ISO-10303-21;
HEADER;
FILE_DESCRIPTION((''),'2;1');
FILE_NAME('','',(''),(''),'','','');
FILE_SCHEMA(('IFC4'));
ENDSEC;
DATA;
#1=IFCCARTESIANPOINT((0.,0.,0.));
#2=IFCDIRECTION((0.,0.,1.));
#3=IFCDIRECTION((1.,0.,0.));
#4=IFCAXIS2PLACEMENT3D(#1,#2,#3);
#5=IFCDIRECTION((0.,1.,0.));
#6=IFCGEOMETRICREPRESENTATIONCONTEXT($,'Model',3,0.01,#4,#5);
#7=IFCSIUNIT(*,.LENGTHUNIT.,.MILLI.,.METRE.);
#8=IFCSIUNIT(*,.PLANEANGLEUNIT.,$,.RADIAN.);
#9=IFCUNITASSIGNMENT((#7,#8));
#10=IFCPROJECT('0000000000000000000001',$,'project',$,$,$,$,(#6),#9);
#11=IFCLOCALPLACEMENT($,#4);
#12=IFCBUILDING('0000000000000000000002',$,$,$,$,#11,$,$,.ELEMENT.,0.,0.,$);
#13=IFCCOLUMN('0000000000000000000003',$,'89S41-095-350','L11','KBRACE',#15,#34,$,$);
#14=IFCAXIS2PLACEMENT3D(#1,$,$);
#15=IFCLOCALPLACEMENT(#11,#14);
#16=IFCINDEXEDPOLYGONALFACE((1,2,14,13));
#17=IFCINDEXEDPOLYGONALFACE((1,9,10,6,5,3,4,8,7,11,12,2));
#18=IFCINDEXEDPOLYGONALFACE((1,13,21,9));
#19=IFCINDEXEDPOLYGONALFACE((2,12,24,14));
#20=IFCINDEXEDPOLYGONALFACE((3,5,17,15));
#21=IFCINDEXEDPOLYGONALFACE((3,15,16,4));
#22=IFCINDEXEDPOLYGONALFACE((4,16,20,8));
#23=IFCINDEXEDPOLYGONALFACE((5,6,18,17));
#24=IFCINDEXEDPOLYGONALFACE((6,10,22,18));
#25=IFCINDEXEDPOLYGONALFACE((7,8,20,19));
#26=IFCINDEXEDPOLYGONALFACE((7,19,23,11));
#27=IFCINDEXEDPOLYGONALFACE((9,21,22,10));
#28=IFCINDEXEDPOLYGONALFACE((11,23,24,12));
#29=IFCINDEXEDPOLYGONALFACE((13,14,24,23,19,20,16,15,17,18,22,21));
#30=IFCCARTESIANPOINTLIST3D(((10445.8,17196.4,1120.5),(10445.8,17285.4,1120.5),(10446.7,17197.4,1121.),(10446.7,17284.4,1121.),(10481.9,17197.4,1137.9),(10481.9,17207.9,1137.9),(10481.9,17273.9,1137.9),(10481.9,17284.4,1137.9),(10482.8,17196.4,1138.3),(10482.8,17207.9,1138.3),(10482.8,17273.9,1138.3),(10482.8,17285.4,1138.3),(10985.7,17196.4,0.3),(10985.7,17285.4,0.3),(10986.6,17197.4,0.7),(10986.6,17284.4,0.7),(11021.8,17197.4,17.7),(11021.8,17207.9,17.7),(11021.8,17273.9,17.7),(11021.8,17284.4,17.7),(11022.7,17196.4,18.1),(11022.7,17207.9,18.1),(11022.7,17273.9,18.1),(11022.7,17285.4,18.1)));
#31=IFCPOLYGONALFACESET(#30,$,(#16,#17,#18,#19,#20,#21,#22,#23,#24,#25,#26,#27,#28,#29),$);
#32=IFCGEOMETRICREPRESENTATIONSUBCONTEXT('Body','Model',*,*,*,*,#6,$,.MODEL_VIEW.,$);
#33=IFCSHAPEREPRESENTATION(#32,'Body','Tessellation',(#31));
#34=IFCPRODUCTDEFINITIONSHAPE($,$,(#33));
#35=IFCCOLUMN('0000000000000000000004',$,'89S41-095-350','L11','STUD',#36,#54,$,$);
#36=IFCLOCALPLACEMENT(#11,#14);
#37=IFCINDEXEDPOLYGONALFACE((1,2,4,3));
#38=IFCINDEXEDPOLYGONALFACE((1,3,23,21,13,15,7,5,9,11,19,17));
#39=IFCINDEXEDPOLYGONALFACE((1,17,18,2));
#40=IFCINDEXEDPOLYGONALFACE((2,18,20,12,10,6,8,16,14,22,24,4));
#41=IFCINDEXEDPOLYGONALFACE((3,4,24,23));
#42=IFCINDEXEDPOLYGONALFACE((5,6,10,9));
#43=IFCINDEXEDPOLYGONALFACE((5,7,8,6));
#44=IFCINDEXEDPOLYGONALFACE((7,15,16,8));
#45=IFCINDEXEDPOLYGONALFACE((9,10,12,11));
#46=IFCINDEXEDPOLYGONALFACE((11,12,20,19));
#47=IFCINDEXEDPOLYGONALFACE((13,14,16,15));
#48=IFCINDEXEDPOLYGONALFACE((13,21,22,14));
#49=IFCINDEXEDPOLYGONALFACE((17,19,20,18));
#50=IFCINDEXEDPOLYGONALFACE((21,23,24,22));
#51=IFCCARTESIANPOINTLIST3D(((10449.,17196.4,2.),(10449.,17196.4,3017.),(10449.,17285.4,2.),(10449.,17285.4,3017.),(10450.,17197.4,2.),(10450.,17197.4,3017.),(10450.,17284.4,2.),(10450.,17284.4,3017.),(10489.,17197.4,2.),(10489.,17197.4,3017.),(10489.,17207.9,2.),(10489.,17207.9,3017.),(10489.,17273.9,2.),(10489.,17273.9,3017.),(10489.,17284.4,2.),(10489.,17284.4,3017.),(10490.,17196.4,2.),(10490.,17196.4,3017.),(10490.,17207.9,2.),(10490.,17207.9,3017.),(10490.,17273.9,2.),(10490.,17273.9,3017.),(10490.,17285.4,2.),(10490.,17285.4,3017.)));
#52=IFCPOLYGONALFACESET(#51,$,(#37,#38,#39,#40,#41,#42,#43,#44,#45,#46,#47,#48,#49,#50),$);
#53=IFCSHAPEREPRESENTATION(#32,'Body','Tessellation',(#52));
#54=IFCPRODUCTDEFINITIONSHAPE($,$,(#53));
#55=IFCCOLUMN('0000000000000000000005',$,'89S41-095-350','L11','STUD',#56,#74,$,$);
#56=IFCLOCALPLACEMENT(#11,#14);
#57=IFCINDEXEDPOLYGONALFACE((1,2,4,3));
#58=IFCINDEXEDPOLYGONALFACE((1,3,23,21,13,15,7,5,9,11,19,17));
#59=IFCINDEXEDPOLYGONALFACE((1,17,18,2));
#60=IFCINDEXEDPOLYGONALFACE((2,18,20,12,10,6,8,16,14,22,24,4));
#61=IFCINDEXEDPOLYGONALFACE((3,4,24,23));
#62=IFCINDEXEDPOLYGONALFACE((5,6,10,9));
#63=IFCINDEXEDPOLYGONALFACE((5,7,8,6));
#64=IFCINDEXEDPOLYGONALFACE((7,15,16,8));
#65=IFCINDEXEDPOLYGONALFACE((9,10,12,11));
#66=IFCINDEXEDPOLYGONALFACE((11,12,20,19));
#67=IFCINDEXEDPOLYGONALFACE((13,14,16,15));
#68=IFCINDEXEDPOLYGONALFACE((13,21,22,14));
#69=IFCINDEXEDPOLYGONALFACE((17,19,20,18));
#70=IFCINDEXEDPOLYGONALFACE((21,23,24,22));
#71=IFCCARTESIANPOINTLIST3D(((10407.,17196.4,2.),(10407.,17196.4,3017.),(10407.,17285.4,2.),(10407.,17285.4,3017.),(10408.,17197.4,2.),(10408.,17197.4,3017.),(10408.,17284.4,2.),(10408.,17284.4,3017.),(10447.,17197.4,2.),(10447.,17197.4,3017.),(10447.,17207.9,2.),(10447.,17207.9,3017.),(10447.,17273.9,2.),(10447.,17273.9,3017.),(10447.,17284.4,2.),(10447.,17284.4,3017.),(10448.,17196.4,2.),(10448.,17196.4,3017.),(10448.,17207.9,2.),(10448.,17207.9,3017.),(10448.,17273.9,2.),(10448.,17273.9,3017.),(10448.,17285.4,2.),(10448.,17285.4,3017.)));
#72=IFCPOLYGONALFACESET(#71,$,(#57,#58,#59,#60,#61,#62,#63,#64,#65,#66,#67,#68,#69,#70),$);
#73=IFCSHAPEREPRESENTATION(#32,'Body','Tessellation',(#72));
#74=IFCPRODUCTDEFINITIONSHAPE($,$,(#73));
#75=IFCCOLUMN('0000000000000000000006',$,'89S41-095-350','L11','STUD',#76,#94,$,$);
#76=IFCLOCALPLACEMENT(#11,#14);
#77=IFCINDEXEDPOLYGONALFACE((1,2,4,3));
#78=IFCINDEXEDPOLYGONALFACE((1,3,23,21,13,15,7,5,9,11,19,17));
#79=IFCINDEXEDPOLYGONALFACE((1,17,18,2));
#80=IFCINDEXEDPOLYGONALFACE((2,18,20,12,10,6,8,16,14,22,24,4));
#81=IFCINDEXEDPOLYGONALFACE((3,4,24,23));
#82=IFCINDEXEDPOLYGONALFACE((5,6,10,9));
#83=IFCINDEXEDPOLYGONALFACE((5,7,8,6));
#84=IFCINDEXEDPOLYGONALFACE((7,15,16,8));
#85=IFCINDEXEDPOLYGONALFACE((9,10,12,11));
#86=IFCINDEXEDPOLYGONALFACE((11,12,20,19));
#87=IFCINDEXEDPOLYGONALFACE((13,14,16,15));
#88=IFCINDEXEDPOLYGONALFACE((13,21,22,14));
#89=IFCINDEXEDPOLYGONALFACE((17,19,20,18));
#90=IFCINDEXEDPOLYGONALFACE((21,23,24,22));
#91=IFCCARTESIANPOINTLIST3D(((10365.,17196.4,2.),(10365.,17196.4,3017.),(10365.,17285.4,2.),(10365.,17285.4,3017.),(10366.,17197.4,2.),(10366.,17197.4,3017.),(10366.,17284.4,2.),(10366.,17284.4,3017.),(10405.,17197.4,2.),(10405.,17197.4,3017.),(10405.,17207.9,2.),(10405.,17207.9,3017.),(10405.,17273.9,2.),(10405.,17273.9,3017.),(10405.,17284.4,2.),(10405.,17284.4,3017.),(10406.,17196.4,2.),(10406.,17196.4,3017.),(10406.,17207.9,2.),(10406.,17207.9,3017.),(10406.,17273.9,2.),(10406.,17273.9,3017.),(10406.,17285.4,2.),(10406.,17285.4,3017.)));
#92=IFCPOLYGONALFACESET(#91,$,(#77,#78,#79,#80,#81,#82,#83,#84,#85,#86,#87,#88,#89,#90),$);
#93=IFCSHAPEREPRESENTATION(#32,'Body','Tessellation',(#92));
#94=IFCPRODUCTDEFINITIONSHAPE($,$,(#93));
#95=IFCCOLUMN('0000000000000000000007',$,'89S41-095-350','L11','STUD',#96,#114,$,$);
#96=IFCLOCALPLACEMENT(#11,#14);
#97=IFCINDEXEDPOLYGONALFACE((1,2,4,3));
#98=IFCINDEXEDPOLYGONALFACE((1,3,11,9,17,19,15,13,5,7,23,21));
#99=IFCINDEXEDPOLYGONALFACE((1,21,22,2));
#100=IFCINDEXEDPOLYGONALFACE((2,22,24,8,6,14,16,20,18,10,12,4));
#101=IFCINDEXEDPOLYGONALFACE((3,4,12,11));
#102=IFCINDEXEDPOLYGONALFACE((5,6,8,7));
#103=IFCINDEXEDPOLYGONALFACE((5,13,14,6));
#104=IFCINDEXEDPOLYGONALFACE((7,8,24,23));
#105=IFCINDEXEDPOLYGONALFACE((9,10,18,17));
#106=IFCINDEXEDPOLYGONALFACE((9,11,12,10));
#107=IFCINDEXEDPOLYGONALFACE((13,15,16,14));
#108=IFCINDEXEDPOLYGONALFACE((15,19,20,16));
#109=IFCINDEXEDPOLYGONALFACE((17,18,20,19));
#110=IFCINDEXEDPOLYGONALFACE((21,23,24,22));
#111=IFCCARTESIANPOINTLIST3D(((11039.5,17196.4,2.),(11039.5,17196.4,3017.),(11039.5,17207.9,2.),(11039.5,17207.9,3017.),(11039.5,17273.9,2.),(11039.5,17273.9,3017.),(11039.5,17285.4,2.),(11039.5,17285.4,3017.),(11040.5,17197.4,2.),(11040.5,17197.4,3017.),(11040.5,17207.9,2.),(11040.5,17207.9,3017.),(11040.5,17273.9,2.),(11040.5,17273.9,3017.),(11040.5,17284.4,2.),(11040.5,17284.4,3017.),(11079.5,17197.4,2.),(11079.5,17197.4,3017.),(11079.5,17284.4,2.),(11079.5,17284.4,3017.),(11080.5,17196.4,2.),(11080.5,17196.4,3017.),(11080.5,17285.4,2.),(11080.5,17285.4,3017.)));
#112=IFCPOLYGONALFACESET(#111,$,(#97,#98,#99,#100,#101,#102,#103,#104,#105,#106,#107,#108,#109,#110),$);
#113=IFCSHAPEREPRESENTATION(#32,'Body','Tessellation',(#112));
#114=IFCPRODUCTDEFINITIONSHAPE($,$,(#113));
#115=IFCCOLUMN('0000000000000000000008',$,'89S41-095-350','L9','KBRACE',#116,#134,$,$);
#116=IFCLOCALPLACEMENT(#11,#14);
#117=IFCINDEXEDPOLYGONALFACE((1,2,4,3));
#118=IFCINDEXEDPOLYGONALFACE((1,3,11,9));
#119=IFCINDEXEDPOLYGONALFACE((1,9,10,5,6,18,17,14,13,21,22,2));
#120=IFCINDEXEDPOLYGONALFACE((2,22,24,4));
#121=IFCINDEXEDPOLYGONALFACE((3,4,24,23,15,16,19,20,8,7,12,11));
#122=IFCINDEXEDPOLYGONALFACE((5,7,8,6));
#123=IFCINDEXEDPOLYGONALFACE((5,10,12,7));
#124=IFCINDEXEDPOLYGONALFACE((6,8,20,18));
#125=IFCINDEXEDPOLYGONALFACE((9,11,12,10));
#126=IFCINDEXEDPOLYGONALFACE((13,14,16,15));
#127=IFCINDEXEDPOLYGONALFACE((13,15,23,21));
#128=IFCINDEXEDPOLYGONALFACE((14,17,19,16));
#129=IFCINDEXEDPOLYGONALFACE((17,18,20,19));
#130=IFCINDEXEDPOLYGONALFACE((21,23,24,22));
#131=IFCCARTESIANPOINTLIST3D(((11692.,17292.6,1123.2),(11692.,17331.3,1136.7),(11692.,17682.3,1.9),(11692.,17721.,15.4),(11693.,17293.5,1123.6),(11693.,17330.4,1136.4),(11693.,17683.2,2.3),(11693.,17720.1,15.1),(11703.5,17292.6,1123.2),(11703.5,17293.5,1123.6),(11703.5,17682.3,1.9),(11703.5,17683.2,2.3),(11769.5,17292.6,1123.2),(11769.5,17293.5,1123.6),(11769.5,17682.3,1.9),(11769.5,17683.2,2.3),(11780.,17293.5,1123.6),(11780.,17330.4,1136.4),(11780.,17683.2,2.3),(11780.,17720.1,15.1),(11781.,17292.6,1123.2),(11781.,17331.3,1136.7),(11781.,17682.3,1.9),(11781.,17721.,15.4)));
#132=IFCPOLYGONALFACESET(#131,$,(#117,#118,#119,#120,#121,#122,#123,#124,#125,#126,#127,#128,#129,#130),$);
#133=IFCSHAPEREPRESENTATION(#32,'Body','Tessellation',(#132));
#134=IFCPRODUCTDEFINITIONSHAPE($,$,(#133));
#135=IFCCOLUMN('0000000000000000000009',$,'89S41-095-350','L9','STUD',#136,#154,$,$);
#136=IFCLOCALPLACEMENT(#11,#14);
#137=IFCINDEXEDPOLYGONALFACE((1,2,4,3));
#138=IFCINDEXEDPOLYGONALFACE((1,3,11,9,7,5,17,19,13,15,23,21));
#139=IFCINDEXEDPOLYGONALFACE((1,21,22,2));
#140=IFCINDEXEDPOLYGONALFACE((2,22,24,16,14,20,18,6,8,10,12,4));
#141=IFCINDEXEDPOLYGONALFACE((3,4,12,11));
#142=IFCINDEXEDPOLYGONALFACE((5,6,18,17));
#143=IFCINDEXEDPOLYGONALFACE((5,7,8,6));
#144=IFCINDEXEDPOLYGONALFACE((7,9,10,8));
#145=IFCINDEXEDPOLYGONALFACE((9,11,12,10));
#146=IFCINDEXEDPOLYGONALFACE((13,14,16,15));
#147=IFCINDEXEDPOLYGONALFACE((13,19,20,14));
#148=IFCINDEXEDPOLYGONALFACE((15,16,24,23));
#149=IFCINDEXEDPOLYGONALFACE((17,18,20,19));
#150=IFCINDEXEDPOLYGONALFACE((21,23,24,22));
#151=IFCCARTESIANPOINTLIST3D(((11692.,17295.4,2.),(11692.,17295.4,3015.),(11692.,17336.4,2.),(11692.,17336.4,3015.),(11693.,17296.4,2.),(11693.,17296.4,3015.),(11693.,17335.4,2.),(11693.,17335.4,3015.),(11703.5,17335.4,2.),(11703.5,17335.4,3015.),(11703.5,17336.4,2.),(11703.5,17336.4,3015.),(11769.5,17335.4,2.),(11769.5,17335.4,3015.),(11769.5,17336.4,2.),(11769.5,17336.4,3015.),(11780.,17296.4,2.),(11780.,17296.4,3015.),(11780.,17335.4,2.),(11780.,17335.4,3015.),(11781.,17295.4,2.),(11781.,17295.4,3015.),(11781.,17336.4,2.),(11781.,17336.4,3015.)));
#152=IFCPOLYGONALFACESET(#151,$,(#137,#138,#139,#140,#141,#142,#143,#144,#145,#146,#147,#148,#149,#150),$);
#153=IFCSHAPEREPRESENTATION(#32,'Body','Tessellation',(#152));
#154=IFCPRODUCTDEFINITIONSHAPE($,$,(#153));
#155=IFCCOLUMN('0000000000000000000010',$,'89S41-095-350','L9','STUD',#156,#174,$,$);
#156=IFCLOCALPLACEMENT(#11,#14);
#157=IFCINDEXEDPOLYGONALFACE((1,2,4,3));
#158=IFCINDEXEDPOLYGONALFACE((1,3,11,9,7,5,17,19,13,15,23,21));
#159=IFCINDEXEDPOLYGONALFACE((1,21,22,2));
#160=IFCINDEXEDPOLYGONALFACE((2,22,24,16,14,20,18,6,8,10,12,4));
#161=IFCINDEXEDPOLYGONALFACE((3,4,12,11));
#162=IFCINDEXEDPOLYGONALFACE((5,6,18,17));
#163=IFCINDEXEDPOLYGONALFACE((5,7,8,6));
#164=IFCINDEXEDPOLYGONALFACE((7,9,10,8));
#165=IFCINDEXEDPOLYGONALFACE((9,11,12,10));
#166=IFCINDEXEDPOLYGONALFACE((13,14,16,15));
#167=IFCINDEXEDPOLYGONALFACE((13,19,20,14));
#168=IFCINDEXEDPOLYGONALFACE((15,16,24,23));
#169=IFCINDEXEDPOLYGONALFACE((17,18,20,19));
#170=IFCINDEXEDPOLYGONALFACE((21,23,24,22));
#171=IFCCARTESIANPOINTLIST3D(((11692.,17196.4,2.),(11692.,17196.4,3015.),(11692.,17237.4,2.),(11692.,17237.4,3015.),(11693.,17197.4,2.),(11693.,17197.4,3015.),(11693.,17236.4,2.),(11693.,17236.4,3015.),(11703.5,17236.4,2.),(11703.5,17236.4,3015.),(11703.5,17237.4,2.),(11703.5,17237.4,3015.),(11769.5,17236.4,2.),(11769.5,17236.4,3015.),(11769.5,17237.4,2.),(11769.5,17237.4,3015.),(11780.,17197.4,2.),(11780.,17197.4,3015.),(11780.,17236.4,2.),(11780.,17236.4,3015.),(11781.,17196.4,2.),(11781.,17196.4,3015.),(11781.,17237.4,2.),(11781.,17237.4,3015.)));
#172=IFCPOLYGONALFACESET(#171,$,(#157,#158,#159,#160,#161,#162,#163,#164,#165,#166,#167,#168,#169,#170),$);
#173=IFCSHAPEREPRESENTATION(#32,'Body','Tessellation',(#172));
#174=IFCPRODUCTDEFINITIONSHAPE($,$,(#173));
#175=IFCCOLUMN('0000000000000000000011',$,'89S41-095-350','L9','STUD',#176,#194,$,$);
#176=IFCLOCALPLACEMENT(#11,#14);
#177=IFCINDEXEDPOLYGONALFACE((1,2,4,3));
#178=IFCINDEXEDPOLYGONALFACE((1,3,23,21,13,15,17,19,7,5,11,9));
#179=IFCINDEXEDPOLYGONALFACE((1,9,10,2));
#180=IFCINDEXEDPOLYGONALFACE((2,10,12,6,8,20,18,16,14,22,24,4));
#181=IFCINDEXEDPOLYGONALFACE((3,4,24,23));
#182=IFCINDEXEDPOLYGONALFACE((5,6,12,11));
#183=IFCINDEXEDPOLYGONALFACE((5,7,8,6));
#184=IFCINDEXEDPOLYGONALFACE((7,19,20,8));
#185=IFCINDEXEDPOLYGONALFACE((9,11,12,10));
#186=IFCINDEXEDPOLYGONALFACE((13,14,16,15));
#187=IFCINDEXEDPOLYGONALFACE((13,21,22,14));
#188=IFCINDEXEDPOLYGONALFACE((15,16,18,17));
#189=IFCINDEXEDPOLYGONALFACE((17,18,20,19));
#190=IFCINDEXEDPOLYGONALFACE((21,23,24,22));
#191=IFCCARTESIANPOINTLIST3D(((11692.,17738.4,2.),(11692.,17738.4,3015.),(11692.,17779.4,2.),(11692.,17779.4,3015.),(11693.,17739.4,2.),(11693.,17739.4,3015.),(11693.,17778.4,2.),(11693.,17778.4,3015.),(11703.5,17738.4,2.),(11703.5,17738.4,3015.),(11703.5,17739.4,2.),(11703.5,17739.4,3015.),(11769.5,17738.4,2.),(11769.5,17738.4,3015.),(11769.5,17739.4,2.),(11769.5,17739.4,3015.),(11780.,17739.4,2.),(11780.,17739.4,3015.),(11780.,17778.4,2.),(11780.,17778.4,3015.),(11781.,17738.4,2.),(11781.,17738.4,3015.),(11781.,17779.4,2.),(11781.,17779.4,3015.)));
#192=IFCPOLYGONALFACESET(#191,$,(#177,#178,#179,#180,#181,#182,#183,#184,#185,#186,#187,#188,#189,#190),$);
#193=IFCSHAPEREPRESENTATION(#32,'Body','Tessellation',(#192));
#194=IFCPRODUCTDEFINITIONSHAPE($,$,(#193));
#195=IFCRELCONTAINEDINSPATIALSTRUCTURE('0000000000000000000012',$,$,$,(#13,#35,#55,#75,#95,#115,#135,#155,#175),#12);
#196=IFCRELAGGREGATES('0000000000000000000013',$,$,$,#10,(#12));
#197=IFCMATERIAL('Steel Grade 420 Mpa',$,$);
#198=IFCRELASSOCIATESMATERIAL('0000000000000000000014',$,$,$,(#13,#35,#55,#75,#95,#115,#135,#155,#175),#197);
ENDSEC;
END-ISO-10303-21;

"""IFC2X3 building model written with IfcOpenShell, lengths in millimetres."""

from ifc_helpers import new_model, si_unit, direction, frame, origin, origin_with_axes, origin_2d_with_axis, place, context, subcontext, project, spatial, c_section, extrude, source, transform, mapped, material, element, save


model = new_model("IFC2X3")

# Units and contexts
model_context = context("Model", 3, precision=0.01, world=origin_with_axes(), true_north=direction((0.0, 1.0, 0.0)))
body_context = subcontext(model_context, "Body", "Model", "MODEL_VIEW")
ifc_project = project(units=[si_unit("LENGTHUNIT", "METRE", prefix="MILLI"), si_unit("PLANEANGLEUNIT", "RADIAN")], contexts=[model_context])

# Building
building_placement = place(None, origin_with_axes())
building = spatial("IfcBuilding", under=ifc_project, at=building_placement, CompositionType="ELEMENT", ElevationOfRefHeight=0.0, ElevationOfTerrain=0.0)

# Columns
ifc_material = material(Name="Steel Grade 420 Mpa")
shared_shape_1 = source(origin(), body_context, "Body", "SweptSolid", [
    extrude(c_section(Depth=89.0, Width=41.0, WallThickness=1.0, Girth=11.5, at=origin_2d_with_axis()), origin_with_axes(), (0.0, 0.0, 1.0), 1243.6),
])
column_1_placement = place(None, frame((11004.2, 17240.9, 9.2), z_axis=(-0.43416, 0.0, 0.900836), x_axis=(0.900836, 0.0, 0.43416)))
element("IfcColumn", 1, at=column_1_placement, inside=building, material=ifc_material, Name="89S41-095-350", Description="L11", ObjectType="KBRACE", context=body_context, shape_type="MappedRepresentation", body=[
    mapped(shared_shape_1, transform((0.0, 0.0, 0.0), scale=1.0)),
])
shared_shape_2 = source(origin(), body_context, "Body", "SweptSolid", [
    extrude(c_section(Depth=89.0, Width=41.0, WallThickness=1.0, Girth=11.5, at=origin_2d_with_axis()), origin_with_axes(), (0.0, 0.0, 1.0), 3015.0),
])
column_2_placement = place(None, frame((10469.5, 17240.9, 2.0), z_axis=(0.0, 0.0, 1.0), x_axis=(1.0, 0.0, 0.0)))
element("IfcColumn", 2, at=column_2_placement, inside=building, material=ifc_material, Name="89S41-095-350", Description="L11", ObjectType="STUD", context=body_context, shape_type="MappedRepresentation", body=[
    mapped(shared_shape_2, transform((0.0, 0.0, 0.0), scale=1.0)),
])
shared_shape_3 = source(origin(), body_context, "Body", "SweptSolid", [
    extrude(c_section(Depth=89.0, Width=41.0, WallThickness=1.0, Girth=11.5, at=origin_2d_with_axis()), origin_with_axes(), (0.0, 0.0, 1.0), 3015.0),
])
column_3_placement = place(None, frame((10427.5, 17240.9, 2.0), z_axis=(0.0, 0.0, 1.0), x_axis=(1.0, 0.0, 0.0)))
element("IfcColumn", 3, at=column_3_placement, inside=building, material=ifc_material, Name="89S41-095-350", Description="L11", ObjectType="STUD", context=body_context, shape_type="MappedRepresentation", body=[
    mapped(shared_shape_3, transform((0.0, 0.0, 0.0), scale=1.0)),
])
shared_shape_4 = source(origin(), body_context, "Body", "SweptSolid", [
    extrude(c_section(Depth=89.0, Width=41.0, WallThickness=1.0, Girth=11.5, at=origin_2d_with_axis()), origin_with_axes(), (0.0, 0.0, 1.0), 3015.0),
])
column_4_placement = place(None, frame((10385.5, 17240.9, 2.0), z_axis=(0.0, 0.0, 1.0), x_axis=(1.0, 0.0, 0.0)))
element("IfcColumn", 4, at=column_4_placement, inside=building, material=ifc_material, Name="89S41-095-350", Description="L11", ObjectType="STUD", context=body_context, shape_type="MappedRepresentation", body=[
    mapped(shared_shape_4, transform((0.0, 0.0, 0.0), scale=1.0)),
])
shared_shape_5 = source(origin(), body_context, "Body", "SweptSolid", [
    extrude(c_section(Depth=89.0, Width=41.0, WallThickness=1.0, Girth=11.5, at=origin_2d_with_axis()), origin_with_axes(), (0.0, 0.0, 1.0), 3015.0),
])
column_5_placement = place(None, frame((11060.0, 17240.9, 2.0), z_axis=(0.0, 0.0, 1.0), x_axis=(-1.0, 0.0, 0.0)))
element("IfcColumn", 5, at=column_5_placement, inside=building, material=ifc_material, Name="89S41-095-350", Description="L11", ObjectType="STUD", context=body_context, shape_type="MappedRepresentation", body=[
    mapped(shared_shape_5, transform((0.0, 0.0, 0.0), scale=1.0)),
])
shared_shape_6 = source(origin(), body_context, "Body", "SweptSolid", [
    extrude(c_section(Depth=89.0, Width=41.0, WallThickness=1.0, Girth=11.5, at=origin_2d_with_axis()), origin_with_axes(), (0.0, 0.0, 1.0), 1187.1),
])
column_6_placement = place(None, frame((11736.5, 17701.7, 8.7), z_axis=(0.0, -0.328306, 0.944572), x_axis=(0.0, -0.944572, -0.328306)))
element("IfcColumn", 6, at=column_6_placement, inside=building, material=ifc_material, Name="89S41-095-350", Description="L9", ObjectType="KBRACE", context=body_context, shape_type="MappedRepresentation", body=[
    mapped(shared_shape_6, transform((0.0, 0.0, 0.0), scale=1.0)),
])
shared_shape_7 = source(origin(), body_context, "Body", "SweptSolid", [
    extrude(c_section(Depth=89.0, Width=41.0, WallThickness=1.0, Girth=11.5, at=origin_2d_with_axis()), origin_with_axes(), (0.0, 0.0, 1.0), 3013.0),
])
column_7_placement = place(None, frame((11736.5, 17315.9, 2.0), z_axis=(0.0, 0.0, 1.0), x_axis=(0.0, 1.0, 0.0)))
element("IfcColumn", 7, at=column_7_placement, inside=building, material=ifc_material, Name="89S41-095-350", Description="L9", ObjectType="STUD", context=body_context, shape_type="MappedRepresentation", body=[
    mapped(shared_shape_7, transform((0.0, 0.0, 0.0), scale=1.0)),
])
shared_shape_8 = source(origin(), body_context, "Body", "SweptSolid", [
    extrude(c_section(Depth=89.0, Width=41.0, WallThickness=1.0, Girth=11.5, at=origin_2d_with_axis()), origin_with_axes(), (0.0, 0.0, 1.0), 3013.0),
])
column_8_placement = place(None, frame((11736.5, 17216.9, 2.0), z_axis=(0.0, 0.0, 1.0), x_axis=(0.0, 1.0, 0.0)))
element("IfcColumn", 8, at=column_8_placement, inside=building, material=ifc_material, Name="89S41-095-350", Description="L9", ObjectType="STUD", context=body_context, shape_type="MappedRepresentation", body=[
    mapped(shared_shape_8, transform((0.0, 0.0, 0.0), scale=1.0)),
])
shared_shape_9 = source(origin(), body_context, "Body", "SweptSolid", [
    extrude(c_section(Depth=89.0, Width=41.0, WallThickness=1.0, Girth=11.5, at=origin_2d_with_axis()), origin_with_axes(), (0.0, 0.0, 1.0), 3013.0),
])
column_9_placement = place(None, frame((11736.5, 17758.9, 2.0), z_axis=(0.0, 0.0, 1.0), x_axis=(0.0, -1.0, 0.0)))
element("IfcColumn", 9, at=column_9_placement, inside=building, material=ifc_material, Name="89S41-095-350", Description="L9", ObjectType="STUD", context=body_context, shape_type="MappedRepresentation", body=[
    mapped(shared_shape_9, transform((0.0, 0.0, 0.0), scale=1.0)),
])

save(model, "model.ifc")
